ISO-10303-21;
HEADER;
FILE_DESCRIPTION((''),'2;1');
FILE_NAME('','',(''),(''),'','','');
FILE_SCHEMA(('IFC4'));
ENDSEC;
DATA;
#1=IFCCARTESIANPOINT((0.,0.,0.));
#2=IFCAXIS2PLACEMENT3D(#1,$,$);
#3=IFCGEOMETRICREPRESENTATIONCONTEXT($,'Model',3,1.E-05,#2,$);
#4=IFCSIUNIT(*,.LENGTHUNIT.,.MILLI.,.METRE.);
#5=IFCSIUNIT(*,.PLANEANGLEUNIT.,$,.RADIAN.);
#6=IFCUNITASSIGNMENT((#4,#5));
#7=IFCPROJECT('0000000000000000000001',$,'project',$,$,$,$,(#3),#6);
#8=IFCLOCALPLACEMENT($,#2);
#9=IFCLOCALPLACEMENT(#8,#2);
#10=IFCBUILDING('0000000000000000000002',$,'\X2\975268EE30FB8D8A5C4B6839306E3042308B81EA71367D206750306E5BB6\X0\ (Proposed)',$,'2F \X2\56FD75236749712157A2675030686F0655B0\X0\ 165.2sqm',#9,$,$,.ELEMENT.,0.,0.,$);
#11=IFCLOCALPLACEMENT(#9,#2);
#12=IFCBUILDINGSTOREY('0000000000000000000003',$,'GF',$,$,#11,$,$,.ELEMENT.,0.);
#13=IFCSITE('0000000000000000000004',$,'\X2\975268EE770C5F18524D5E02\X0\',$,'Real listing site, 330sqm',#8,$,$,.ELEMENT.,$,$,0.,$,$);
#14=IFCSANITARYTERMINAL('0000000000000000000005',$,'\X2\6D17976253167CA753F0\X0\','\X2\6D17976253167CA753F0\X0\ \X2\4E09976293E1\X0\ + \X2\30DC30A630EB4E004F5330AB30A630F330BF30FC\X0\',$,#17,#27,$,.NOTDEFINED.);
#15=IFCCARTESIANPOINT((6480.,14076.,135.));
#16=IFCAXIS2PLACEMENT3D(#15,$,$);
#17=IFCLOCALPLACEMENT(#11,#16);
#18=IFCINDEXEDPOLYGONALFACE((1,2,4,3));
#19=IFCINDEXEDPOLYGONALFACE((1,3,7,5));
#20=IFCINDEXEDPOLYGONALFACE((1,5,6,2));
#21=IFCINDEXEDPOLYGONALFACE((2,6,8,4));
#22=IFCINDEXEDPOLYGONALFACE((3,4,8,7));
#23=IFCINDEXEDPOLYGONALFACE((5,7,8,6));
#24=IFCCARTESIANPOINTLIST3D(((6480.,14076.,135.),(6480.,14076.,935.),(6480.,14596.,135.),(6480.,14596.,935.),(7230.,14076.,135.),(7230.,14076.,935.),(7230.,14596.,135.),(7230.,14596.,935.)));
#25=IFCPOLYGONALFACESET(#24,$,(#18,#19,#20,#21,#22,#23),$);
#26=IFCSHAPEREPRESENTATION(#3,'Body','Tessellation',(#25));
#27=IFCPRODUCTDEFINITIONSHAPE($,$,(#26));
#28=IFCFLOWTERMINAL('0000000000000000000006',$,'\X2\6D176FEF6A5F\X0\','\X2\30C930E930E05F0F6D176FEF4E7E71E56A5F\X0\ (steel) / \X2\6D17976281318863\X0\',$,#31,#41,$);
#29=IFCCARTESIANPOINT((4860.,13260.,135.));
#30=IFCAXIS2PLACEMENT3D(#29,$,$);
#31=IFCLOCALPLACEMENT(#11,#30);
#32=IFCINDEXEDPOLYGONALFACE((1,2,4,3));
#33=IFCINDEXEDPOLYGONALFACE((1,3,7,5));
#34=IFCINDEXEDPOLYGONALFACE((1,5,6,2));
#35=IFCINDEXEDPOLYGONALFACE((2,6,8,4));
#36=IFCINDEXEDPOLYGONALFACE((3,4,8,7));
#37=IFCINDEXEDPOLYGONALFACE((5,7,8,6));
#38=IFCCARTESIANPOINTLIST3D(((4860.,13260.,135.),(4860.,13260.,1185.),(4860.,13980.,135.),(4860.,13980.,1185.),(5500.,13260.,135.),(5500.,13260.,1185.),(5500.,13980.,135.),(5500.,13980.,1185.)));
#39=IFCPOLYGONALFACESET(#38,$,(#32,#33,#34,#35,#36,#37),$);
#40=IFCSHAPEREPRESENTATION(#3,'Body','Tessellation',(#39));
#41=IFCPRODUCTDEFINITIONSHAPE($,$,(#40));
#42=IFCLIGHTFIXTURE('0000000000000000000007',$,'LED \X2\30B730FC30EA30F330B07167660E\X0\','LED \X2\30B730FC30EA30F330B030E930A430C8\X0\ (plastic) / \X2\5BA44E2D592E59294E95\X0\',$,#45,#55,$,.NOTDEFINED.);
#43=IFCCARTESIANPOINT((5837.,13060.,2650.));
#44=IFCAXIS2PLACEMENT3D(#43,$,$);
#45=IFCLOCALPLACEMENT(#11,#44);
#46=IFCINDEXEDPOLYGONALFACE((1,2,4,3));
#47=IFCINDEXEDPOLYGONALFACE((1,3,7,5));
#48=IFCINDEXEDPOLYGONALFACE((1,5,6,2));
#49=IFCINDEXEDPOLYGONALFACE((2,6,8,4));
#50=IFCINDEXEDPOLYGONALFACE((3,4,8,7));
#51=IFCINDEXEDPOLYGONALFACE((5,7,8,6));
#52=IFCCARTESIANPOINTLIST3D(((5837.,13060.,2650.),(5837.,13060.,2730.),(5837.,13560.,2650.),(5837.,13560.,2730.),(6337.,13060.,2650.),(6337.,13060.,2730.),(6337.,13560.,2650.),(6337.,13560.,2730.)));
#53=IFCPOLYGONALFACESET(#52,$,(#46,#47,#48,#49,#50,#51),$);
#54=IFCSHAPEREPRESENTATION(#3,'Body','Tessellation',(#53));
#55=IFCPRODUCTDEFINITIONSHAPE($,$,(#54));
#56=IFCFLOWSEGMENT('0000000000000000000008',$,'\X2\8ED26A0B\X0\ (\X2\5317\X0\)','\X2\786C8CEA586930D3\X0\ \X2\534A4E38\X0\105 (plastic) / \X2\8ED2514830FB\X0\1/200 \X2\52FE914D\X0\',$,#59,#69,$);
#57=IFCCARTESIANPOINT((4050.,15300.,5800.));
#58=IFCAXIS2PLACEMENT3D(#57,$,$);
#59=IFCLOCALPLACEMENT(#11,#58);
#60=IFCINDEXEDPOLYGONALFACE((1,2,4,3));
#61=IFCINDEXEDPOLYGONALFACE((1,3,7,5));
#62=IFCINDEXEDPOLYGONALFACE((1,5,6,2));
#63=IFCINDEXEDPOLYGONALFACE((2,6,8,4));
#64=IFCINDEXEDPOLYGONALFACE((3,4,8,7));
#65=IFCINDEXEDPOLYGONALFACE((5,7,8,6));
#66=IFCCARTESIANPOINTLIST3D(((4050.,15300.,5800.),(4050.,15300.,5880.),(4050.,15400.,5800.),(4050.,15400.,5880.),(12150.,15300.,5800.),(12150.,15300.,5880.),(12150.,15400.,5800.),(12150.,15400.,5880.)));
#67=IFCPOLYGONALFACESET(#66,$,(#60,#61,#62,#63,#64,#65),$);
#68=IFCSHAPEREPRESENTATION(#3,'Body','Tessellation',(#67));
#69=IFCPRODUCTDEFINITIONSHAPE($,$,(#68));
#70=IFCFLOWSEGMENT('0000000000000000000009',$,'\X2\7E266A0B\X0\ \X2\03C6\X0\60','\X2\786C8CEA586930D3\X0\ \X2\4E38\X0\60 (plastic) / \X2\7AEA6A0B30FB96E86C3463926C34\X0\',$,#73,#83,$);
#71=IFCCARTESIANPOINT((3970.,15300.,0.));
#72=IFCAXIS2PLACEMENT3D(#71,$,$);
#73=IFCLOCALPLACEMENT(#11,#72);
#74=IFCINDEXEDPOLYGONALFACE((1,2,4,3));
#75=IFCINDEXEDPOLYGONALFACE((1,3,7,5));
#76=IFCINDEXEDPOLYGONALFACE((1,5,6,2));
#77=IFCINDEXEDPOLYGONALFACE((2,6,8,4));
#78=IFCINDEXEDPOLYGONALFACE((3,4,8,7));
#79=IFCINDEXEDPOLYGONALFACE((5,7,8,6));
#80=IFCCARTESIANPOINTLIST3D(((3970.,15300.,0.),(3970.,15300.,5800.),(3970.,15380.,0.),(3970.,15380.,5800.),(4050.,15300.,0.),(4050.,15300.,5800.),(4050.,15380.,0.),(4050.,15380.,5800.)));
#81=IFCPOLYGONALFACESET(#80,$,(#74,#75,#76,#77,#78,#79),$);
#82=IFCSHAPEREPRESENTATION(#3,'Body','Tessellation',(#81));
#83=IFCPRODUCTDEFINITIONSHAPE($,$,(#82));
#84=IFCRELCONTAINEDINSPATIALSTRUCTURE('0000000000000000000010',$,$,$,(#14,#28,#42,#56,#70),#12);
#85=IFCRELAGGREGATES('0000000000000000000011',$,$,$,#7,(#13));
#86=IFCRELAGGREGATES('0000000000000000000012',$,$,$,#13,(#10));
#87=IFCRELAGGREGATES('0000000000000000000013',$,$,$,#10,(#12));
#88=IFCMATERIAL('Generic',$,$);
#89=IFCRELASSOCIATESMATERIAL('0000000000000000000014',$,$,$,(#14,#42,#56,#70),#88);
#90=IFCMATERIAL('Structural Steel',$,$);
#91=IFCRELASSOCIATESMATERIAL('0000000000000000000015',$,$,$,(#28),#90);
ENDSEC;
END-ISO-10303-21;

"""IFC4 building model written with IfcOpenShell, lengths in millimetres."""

from ifc_helpers import new_model, si_unit, frame, frame_2d, origin, place, context, project, spatial, rectangle, extrude, material, element, save


model = new_model("IFC4")

# Units and contexts
model_context = context("Model", 3, precision=1e-05, world=origin())
ifc_project = project(units=[si_unit("LENGTHUNIT", "METRE", prefix="MILLI"), si_unit("PLANEANGLEUNIT", "RADIAN")], contexts=[model_context])

# Site, building, storey
site_placement = place(None, origin())
site = spatial("IfcSite", under=ifc_project, at=site_placement, Name="青森県弘前市", ObjectType="Real listing site, 330sqm", CompositionType="ELEMENT", RefElevation=0.0)
building_placement = place(site_placement, origin())
building = spatial("IfcBuilding", under=site, at=building_placement, Name="青森・越屋根のある自然素材の家 (Proposed)", ObjectType="2F 国産杉無垢材と漆喰 165.2sqm", CompositionType="ELEMENT", ElevationOfRefHeight=0.0, ElevationOfTerrain=0.0)
storey_placement = place(building_placement, origin())
storey = spatial("IfcBuildingStorey", under=building, at=storey_placement, Name="GF", CompositionType="ELEMENT", Elevation=0.0)

# Sanitary terminal
ifc_material_1 = material(Name="Generic")
sanitary_terminal_placement = place(storey_placement, frame((6480.0, 14076.0, 135.0)))
element("IfcSanitaryTerminal", 1, at=sanitary_terminal_placement, inside=storey, material=ifc_material_1, Name="洗面化粧台", Description="洗面化粧台 三面鏡 + ボウル一体カウンター", PredefinedType="NOTDEFINED", context=model_context, shape_type="SweptSolid", body=[
    extrude(rectangle(XDim=750.0, YDim=520.0, at=frame_2d((375.0, 260.0))), frame((6480.0, 14076.0, 135.0)), (0.0, 0.0, 1.0), 800.0),
])

# Flow terminal
ifc_material_2 = material(Name="Structural Steel")
flow_terminal_placement = place(storey_placement, frame((4860.0, 13260.0, 135.0)))
element("IfcFlowTerminal", 2, at=flow_terminal_placement, inside=storey, material=ifc_material_2, Name="洗濯機", Description="ドラム式洗濯乾燥機 (steel) / 洗面脱衣", context=model_context, shape_type="SweptSolid", body=[
    extrude(rectangle(XDim=640.0, YDim=720.0, at=frame_2d((320.0, 360.0))), frame((4860.0, 13260.0, 135.0)), (0.0, 0.0, 1.0), 1050.0),
])

# Light fixture
light_fixture_placement = place(storey_placement, frame((5837.0, 13060.0, 2650.0)))
element("IfcLightFixture", 3, at=light_fixture_placement, inside=storey, material=ifc_material_1, Name="LED シーリング照明", Description="LED シーリングライト (plastic) / 室中央天井", PredefinedType="NOTDEFINED", context=model_context, shape_type="SweptSolid", body=[
    extrude(rectangle(XDim=500.0, YDim=500.0, at=frame_2d((250.0, 250.0))), frame((5837.0, 13060.0, 2650.0)), (0.0, 0.0, 1.0), 80.0),
])

# Flow segments
flow_segment_1_placement = place(storey_placement, frame((4050.0, 15300.0, 5800.0)))
element("IfcFlowSegment", 4, at=flow_segment_1_placement, inside=storey, material=ifc_material_1, Name="軒樋 (北)", Description="硬質塩ビ 半丸105 (plastic) / 軒先・1/200 勾配", context=model_context, shape_type="SweptSolid", body=[
    extrude(rectangle(XDim=8100.0, YDim=100.0, at=frame_2d((4050.0, 50.0))), frame((4050.0, 15300.0, 5800.0)), (0.0, 0.0, 1.0), 80.0),
])
flow_segment_2_placement = place(storey_placement, frame((3970.0, 15300.0, 0.0)))
element("IfcFlowSegment", 5, at=flow_segment_2_placement, inside=storey, material=ifc_material_1, Name="縦樋 φ60", Description="硬質塩ビ 丸60 (plastic) / 竪樋・雨水排水", context=model_context, shape_type="SweptSolid", body=[
    extrude(rectangle(XDim=80.0, YDim=80.0, at=frame_2d((40.0, 40.0))), frame((3970.0, 15300.0, 0.0)), (0.0, 0.0, 1.0), 5800.0),
])

save(model, "model.ifc")
